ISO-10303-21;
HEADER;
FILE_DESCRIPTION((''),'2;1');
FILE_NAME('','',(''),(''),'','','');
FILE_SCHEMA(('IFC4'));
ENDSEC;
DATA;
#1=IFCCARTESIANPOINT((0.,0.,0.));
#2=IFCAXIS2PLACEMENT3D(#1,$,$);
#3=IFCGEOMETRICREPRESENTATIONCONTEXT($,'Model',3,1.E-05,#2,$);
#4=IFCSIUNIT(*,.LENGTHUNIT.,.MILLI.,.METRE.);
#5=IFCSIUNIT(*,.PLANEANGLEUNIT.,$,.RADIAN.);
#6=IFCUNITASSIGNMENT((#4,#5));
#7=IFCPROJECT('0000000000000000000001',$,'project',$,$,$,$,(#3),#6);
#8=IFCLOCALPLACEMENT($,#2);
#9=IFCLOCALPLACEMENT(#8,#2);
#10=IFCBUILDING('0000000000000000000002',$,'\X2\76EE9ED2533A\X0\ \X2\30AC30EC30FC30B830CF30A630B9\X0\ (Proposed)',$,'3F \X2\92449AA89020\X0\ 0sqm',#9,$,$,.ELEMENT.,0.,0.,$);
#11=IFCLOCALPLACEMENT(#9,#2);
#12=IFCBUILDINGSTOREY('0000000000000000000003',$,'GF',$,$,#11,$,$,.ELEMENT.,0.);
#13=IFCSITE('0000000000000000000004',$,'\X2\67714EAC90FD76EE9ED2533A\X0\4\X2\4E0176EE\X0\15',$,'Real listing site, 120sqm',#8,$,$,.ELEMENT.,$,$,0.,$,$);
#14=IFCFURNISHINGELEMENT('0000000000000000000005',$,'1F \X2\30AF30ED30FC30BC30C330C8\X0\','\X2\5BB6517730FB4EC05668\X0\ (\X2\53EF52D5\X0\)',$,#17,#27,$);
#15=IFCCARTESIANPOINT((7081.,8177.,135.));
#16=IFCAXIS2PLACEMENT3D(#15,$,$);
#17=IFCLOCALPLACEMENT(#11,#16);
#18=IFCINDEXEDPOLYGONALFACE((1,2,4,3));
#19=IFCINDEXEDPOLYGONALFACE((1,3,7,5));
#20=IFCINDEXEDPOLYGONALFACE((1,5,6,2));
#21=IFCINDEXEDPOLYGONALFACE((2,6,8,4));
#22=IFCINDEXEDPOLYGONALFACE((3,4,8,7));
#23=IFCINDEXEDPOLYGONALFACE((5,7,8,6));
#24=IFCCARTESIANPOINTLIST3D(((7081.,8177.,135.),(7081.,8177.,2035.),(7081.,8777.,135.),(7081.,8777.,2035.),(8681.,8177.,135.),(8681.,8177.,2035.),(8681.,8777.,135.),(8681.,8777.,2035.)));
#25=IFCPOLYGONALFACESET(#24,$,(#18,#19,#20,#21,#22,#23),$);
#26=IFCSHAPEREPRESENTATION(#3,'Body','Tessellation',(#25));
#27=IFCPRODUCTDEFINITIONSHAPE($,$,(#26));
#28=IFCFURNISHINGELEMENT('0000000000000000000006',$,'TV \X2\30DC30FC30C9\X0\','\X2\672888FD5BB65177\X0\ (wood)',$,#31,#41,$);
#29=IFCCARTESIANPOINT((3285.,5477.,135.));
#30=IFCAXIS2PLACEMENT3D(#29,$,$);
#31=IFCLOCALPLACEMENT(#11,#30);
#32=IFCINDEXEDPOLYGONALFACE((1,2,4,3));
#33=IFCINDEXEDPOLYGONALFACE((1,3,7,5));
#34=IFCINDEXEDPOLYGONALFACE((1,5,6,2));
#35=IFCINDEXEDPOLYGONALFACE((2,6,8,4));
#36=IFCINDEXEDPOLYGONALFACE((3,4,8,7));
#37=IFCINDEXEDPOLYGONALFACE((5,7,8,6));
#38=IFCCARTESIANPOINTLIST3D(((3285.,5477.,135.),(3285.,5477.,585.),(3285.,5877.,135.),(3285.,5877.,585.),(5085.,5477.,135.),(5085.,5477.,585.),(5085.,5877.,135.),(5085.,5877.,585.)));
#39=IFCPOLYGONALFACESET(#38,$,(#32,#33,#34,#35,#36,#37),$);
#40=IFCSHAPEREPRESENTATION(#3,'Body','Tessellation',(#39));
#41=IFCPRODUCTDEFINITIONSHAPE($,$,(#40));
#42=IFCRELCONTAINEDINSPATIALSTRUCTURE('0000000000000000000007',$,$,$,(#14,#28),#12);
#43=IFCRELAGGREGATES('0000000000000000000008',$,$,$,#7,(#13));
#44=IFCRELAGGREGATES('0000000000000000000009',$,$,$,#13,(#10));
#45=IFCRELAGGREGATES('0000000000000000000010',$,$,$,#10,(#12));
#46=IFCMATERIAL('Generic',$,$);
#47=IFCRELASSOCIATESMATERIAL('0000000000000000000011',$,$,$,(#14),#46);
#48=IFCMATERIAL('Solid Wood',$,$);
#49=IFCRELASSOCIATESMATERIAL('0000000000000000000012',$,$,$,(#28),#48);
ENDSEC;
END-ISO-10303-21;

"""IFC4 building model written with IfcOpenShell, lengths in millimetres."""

from ifc_helpers import new_model, si_unit, frame, frame_2d, origin, place, context, project, spatial, rectangle, extrude, material, element, save


model = new_model("IFC4")

# Units and contexts
model_context = context("Model", 3, precision=1e-05, world=origin())
ifc_project = project(units=[si_unit("LENGTHUNIT", "METRE", prefix="MILLI"), si_unit("PLANEANGLEUNIT", "RADIAN")], contexts=[model_context])

# Site, building, storey
site_placement = place(None, origin())
site = spatial("IfcSite", under=ifc_project, at=site_placement, Name="東京都目黒区4丁目15", ObjectType="Real listing site, 120sqm", CompositionType="ELEMENT", RefElevation=0.0)
building_placement = place(site_placement, origin())
building = spatial("IfcBuilding", under=site, at=building_placement, Name="目黒区 ガレージハウス (Proposed)", ObjectType="3F 鉄骨造 0sqm", CompositionType="ELEMENT", ElevationOfRefHeight=0.0, ElevationOfTerrain=0.0)
storey_placement = place(building_placement, origin())
storey = spatial("IfcBuildingStorey", under=building, at=storey_placement, Name="GF", CompositionType="ELEMENT", Elevation=0.0)

# Shared definitions
ifc_material_1 = material(Name="Solid Wood")

# Shared definitions
ifc_material_2 = material(Name="Generic")

# Furnishing elements
furnishing_1_placement = place(storey_placement, frame((7081.0, 8177.0, 135.0)))
element("IfcFurnishingElement", 1, at=furnishing_1_placement, inside=storey, material=ifc_material_2, Name="1F クローゼット", Description="家具・什器 (可動)", context=model_context, shape_type="SweptSolid", body=[
    extrude(rectangle(XDim=1600.0, YDim=600.0, at=frame_2d((800.0, 300.0))), frame((7081.0, 8177.0, 135.0)), (0.0, 0.0, 1.0), 1900.0),
])
furnishing_2_placement = place(storey_placement, frame((3285.0, 5477.0, 135.0)))
element("IfcFurnishingElement", 2, at=furnishing_2_placement, inside=storey, material=ifc_material_1, Name="TV ボード", Description="木製家具 (wood)", context=model_context, shape_type="SweptSolid", body=[
    extrude(rectangle(XDim=1800.0, YDim=400.0, at=frame_2d((900.0, 200.0))), frame((3285.0, 5477.0, 135.0)), (0.0, 0.0, 1.0), 450.0),
])

save(model, "model.ifc")
